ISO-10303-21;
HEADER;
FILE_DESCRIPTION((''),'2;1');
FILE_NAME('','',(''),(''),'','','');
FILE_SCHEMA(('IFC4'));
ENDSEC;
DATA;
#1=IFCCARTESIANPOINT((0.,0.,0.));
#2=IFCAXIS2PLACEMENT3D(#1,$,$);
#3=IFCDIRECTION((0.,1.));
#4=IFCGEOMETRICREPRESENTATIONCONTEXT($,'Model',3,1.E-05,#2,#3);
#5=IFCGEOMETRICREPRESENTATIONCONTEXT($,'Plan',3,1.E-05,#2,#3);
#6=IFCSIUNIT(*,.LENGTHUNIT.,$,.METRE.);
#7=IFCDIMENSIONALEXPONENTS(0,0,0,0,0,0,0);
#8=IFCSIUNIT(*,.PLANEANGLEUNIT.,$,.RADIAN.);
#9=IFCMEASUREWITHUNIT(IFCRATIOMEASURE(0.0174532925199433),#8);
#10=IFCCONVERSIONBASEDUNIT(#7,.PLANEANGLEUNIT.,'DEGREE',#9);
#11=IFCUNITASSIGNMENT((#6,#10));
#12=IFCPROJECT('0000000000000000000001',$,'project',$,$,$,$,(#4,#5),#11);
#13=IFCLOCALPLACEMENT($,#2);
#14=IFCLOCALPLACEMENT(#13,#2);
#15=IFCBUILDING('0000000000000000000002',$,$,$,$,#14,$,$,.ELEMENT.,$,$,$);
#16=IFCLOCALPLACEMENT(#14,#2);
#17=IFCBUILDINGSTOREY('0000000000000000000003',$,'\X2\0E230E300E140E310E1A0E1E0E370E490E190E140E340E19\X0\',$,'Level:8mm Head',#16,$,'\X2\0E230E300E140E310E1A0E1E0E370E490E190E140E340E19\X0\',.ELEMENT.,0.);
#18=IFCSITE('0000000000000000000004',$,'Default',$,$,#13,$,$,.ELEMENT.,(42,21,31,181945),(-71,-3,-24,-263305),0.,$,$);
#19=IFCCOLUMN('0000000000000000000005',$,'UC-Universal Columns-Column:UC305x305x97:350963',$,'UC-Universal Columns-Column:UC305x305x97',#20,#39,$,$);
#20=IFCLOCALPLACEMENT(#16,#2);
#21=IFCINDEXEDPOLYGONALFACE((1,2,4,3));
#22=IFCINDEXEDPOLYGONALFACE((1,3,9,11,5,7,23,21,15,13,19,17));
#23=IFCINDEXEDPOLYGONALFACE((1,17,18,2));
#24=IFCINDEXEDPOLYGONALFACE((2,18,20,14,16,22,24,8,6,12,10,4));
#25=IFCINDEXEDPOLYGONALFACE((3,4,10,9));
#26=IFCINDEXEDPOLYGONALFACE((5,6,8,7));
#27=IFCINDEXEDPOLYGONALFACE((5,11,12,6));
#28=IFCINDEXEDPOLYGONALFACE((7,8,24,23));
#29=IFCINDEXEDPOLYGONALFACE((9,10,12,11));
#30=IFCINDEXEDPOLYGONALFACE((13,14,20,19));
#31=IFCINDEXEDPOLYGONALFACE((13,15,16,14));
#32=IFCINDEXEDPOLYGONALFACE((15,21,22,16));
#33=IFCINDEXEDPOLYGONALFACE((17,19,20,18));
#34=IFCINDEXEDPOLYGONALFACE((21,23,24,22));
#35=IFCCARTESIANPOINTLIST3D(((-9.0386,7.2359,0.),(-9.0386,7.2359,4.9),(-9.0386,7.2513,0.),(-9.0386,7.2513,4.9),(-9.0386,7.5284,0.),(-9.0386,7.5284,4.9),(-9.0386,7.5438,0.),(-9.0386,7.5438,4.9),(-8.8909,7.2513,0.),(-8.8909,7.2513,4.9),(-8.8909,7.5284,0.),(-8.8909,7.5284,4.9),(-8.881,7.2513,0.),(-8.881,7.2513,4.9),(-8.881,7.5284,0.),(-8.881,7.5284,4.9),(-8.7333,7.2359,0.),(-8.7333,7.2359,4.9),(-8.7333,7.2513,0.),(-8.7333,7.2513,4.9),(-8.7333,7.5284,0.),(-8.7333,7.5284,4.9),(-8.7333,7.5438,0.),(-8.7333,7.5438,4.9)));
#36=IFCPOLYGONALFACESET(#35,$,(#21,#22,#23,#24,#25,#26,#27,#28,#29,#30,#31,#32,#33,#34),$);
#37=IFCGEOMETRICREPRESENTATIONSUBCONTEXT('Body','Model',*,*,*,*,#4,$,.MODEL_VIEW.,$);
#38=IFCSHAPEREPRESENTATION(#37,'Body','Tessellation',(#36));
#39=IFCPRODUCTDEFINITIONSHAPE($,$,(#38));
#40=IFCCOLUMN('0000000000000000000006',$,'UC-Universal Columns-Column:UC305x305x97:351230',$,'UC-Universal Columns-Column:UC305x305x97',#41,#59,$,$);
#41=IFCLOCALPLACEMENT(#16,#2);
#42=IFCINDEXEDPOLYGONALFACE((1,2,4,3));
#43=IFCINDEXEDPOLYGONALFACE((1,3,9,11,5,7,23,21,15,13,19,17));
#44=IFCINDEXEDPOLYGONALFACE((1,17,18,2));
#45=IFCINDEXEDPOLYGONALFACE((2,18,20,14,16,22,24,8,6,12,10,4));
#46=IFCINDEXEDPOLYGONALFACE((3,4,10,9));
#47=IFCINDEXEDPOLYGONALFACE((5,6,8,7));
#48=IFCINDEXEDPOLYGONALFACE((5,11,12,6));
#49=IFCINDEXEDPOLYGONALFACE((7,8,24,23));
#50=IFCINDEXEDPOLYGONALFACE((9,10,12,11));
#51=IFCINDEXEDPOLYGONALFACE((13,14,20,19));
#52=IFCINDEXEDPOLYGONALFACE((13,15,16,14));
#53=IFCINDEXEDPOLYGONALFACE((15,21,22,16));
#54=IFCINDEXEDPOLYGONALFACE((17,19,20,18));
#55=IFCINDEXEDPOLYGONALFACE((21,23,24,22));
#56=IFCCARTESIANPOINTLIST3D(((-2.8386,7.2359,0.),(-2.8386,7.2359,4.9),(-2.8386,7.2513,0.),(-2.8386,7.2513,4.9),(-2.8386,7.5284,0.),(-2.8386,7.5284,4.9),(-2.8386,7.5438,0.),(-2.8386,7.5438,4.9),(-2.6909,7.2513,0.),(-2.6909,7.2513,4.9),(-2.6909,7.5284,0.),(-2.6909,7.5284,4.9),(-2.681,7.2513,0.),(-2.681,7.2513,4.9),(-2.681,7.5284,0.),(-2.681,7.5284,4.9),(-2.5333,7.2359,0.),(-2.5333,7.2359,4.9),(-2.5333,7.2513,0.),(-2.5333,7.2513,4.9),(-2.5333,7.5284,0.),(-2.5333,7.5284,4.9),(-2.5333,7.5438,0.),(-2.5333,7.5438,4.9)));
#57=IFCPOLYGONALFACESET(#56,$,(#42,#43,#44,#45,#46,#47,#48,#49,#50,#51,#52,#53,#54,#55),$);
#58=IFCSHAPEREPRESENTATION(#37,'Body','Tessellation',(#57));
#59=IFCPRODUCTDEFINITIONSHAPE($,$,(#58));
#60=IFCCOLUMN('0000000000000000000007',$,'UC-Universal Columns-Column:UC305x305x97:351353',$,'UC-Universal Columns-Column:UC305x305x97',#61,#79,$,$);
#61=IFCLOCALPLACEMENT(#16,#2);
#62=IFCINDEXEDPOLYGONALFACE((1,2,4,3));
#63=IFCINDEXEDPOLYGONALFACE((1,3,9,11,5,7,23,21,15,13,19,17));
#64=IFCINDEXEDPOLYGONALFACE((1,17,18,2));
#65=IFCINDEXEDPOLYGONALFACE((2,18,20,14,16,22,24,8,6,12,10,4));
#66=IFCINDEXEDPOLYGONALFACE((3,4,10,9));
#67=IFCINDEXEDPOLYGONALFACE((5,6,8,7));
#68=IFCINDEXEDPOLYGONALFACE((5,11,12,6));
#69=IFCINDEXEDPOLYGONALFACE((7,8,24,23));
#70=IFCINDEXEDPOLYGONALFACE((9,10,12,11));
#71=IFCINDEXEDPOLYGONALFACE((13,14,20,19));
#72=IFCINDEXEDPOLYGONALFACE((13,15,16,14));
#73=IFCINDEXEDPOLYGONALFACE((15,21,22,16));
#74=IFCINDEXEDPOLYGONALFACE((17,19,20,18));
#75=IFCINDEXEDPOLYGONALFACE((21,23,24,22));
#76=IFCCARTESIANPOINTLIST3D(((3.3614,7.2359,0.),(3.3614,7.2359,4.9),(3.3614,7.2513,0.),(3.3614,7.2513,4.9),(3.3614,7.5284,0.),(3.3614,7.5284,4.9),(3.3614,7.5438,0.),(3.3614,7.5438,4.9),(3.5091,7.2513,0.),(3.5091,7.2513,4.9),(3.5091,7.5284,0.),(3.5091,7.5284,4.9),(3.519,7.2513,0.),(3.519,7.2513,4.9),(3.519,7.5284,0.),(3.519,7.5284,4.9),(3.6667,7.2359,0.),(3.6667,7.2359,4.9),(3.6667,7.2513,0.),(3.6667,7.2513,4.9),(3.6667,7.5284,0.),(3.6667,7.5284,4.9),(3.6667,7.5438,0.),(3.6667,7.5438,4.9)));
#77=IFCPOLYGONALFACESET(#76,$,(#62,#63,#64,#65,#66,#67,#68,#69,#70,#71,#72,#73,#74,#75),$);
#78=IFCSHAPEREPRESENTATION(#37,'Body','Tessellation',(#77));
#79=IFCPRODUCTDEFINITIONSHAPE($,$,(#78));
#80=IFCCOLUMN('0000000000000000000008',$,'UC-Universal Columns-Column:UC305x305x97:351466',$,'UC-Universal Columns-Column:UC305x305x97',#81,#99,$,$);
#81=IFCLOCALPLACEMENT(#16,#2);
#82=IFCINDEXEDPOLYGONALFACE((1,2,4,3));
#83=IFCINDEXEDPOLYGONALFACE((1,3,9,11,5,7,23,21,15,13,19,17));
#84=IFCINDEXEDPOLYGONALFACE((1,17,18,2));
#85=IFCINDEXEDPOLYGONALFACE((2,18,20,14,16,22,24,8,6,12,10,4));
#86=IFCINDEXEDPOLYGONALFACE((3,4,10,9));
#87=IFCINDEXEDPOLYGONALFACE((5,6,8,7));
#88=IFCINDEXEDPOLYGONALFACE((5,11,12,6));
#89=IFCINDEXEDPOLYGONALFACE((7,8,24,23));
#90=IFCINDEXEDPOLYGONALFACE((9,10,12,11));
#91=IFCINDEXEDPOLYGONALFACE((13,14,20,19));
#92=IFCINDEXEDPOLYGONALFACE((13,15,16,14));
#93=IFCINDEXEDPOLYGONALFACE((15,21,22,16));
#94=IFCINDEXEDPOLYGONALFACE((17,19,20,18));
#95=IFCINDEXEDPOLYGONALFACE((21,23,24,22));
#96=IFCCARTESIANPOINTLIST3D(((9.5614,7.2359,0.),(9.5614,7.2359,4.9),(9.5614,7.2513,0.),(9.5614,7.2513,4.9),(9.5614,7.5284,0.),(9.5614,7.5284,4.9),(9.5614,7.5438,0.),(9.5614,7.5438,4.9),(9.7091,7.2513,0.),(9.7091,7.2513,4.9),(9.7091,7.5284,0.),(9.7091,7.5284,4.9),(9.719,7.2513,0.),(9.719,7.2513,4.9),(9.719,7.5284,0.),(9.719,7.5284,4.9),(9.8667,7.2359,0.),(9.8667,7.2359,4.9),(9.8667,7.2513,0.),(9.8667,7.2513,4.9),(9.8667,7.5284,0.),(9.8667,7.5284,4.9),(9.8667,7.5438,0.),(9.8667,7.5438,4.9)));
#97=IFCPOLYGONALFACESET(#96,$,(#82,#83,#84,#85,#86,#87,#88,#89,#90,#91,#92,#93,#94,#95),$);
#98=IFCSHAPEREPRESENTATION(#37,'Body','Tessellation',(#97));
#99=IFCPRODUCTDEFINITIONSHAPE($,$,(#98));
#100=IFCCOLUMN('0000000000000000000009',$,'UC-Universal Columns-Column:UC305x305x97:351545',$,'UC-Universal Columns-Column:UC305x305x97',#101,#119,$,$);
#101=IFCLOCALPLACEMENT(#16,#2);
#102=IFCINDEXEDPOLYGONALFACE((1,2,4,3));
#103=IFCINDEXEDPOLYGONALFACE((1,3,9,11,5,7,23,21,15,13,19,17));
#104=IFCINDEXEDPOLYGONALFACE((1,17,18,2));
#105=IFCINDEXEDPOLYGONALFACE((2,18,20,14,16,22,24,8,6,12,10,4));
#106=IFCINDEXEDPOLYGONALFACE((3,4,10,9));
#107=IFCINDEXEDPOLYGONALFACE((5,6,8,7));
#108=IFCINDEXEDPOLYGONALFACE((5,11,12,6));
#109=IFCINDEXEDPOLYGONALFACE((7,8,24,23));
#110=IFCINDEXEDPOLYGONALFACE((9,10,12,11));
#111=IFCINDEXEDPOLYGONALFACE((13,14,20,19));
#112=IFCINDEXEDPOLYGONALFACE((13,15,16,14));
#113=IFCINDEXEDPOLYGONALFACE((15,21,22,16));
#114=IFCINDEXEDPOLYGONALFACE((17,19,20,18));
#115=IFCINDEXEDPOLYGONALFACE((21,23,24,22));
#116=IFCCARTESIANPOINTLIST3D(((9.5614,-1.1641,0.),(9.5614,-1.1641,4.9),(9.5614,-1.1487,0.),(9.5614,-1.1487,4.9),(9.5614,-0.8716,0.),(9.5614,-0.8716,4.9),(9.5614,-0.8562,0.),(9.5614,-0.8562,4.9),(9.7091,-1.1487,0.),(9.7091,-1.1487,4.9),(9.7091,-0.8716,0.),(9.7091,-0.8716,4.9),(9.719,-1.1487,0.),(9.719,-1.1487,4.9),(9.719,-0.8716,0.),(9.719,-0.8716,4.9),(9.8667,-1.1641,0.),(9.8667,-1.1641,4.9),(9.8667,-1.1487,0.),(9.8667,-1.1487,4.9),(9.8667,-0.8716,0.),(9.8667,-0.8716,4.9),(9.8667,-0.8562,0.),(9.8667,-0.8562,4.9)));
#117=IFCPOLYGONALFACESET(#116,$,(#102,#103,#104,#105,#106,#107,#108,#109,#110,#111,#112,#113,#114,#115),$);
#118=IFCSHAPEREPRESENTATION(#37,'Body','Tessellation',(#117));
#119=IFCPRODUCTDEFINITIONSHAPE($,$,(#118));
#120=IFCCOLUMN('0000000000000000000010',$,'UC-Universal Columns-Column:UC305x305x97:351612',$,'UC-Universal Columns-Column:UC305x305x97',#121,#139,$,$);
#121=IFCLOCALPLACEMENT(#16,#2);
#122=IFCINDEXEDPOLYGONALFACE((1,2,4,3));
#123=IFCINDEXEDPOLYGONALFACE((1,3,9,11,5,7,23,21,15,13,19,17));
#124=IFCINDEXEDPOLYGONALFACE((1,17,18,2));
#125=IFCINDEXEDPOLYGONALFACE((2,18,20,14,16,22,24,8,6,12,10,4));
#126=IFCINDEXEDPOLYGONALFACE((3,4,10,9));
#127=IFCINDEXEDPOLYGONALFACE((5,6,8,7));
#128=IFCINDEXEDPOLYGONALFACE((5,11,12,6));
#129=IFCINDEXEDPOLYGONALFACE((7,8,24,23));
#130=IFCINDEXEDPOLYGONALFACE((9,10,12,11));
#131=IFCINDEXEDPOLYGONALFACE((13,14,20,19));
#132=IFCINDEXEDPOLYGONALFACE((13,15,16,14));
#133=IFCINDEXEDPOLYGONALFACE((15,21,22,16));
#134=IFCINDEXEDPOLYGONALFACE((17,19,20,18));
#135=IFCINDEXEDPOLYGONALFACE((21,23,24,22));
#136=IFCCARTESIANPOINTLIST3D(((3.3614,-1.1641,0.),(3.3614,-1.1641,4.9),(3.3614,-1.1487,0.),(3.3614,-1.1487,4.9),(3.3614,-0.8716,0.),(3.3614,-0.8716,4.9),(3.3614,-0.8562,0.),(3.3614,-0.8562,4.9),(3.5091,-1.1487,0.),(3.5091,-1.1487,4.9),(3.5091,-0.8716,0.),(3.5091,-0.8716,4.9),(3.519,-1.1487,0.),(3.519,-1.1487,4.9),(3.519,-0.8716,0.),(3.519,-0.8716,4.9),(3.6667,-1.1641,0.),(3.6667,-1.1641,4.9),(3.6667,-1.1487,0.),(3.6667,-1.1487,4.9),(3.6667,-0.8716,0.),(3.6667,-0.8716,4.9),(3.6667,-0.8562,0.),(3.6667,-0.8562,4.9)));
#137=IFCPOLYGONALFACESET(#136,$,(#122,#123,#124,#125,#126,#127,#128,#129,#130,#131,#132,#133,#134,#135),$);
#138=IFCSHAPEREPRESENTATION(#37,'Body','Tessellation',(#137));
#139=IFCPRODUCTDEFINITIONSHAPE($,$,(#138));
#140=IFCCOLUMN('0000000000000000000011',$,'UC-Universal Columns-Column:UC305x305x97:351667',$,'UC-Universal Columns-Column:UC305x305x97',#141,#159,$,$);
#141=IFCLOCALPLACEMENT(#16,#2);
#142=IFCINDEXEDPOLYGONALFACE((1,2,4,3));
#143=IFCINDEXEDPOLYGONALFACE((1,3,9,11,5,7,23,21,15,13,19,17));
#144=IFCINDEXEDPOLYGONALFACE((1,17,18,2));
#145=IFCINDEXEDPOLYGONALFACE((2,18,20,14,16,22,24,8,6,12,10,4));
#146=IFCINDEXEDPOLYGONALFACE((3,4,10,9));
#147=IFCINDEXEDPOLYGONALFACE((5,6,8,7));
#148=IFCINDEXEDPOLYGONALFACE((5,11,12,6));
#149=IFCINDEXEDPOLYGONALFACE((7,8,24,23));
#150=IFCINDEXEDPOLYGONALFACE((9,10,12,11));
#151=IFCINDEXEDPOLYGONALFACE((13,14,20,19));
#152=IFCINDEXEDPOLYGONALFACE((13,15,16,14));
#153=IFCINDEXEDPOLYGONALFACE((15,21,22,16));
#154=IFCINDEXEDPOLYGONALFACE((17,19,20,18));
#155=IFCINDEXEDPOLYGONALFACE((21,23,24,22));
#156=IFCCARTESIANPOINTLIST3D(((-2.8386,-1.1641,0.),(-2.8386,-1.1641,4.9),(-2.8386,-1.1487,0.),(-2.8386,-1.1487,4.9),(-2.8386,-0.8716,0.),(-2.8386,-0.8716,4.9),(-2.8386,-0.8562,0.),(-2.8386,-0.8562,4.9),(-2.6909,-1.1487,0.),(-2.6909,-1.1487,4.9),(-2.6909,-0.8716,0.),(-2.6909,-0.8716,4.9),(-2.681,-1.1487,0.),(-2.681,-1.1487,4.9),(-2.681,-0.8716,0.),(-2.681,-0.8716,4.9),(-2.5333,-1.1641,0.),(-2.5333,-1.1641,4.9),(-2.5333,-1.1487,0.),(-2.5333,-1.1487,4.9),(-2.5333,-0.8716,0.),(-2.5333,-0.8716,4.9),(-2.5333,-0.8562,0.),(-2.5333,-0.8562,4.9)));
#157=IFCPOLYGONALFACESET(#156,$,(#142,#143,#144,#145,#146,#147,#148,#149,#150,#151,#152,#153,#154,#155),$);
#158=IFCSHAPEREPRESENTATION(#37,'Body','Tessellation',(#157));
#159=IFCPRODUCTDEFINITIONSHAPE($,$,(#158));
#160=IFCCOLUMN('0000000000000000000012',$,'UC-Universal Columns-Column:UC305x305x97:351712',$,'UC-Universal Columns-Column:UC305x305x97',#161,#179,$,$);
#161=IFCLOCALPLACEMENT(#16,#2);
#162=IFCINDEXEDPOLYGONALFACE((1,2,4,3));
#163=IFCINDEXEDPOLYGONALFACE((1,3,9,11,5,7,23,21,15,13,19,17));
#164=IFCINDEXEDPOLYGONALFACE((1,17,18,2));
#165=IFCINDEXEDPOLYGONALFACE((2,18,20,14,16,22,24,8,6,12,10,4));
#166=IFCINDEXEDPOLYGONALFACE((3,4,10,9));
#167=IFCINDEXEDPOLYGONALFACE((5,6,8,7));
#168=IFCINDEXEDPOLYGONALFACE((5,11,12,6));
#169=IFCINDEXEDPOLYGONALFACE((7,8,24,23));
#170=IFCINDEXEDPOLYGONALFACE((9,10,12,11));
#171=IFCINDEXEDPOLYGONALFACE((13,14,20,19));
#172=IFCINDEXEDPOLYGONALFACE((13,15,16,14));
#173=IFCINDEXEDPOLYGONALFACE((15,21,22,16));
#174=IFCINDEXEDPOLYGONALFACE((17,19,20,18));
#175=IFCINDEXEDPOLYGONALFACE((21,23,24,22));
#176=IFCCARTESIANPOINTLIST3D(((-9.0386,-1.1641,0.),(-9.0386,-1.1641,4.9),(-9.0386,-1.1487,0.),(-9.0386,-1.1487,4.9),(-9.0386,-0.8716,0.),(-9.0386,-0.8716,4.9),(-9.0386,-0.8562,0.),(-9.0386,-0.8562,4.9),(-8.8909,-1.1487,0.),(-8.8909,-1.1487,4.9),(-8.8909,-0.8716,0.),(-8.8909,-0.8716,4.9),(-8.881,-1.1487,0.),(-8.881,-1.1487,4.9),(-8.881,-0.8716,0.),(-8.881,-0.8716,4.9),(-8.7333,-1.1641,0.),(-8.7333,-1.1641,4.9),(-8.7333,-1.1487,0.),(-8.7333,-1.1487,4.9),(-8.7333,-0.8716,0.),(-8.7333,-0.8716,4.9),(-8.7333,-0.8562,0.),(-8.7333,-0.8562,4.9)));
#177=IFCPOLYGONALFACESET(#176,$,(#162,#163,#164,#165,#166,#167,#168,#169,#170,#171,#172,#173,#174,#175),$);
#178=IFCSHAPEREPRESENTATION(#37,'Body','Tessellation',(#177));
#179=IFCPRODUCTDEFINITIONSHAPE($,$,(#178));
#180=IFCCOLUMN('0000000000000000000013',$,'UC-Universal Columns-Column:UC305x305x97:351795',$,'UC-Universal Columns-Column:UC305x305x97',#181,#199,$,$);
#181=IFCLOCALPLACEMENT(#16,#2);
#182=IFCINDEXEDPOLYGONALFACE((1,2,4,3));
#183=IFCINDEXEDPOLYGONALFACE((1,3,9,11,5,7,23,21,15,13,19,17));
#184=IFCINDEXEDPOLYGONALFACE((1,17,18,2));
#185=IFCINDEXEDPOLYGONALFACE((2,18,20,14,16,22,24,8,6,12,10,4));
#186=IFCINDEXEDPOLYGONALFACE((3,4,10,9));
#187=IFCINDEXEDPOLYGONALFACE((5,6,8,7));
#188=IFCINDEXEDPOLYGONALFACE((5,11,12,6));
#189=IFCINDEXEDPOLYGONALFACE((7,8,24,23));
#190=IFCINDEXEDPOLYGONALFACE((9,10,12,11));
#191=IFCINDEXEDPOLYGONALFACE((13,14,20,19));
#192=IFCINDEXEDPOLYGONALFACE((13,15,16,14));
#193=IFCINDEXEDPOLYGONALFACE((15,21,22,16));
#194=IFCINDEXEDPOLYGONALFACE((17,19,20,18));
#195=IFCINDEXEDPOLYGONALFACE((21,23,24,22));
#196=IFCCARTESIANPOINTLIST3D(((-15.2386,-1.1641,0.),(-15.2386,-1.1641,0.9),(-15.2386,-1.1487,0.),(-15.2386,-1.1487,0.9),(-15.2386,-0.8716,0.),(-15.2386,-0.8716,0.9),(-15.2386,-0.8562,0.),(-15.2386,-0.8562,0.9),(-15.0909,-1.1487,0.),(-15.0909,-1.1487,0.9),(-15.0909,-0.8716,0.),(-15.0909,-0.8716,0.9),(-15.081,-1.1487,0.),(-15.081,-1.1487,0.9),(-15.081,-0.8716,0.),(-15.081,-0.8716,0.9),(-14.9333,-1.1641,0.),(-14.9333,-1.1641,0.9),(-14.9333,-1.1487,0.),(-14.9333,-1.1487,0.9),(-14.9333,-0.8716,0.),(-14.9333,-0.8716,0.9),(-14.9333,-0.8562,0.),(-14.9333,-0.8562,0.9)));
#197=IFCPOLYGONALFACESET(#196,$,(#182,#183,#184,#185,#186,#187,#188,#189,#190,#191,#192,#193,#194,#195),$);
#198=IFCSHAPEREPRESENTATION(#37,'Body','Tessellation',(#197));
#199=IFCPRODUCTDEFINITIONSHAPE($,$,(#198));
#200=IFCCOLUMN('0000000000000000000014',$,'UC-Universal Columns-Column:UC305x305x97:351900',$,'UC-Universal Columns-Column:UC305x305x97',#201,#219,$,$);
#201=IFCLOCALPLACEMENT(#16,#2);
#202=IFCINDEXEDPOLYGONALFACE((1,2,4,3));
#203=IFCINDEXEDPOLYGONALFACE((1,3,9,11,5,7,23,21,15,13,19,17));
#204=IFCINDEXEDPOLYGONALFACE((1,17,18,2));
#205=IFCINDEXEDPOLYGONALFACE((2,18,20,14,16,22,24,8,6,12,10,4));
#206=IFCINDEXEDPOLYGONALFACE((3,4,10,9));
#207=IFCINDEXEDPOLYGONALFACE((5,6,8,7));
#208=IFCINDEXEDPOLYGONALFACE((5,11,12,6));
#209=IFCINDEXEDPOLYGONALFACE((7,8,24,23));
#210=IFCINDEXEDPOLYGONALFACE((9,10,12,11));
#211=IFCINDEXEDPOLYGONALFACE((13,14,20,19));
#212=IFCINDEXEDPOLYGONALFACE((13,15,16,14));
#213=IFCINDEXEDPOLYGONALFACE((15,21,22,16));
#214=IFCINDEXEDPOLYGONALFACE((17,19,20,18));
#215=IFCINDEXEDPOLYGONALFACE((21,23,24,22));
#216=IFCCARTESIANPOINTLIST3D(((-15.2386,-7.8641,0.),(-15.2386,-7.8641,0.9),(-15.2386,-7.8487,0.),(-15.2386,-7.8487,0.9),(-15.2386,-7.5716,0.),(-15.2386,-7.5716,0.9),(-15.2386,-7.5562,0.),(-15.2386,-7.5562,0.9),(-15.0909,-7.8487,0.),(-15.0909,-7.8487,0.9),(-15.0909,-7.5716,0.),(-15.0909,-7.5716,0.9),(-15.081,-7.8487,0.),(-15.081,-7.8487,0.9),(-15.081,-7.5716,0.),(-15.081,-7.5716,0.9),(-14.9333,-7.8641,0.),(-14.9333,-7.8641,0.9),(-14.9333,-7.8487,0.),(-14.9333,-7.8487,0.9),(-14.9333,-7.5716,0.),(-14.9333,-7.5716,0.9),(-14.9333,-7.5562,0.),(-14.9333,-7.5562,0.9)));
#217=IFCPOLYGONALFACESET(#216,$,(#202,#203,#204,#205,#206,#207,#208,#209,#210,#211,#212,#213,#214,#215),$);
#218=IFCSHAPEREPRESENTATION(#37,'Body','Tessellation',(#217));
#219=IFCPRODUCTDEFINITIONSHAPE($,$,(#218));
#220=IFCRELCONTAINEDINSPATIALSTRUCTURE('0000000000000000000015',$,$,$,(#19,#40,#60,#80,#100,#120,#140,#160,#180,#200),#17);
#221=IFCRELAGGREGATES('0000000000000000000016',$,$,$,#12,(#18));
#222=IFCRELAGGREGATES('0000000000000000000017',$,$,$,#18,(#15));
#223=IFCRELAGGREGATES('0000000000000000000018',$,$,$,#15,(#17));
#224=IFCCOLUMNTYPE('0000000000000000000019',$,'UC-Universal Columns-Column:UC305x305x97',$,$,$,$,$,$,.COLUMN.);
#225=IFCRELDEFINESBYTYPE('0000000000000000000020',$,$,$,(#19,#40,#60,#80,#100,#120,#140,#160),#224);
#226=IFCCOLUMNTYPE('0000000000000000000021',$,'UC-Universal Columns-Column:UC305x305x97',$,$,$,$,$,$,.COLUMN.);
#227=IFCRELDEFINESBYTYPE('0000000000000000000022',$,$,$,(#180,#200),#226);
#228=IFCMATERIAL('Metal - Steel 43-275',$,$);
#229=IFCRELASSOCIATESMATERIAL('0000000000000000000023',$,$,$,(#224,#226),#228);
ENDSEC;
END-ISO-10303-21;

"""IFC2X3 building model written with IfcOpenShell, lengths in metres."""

from ifc_helpers import new_model, entity, si_unit, converted_unit, direction, frame, frame_2d, origin, place, context, subcontext, project, spatial, i_section, extrude, source, transform, mapped, material, type_object, type_shapes, element, save


model = new_model("IFC2X3")

# Units and contexts
model_context = context("Model", 3, precision=1e-05, world=origin(), true_north=direction((0.0, 1.0)))
plan_context = context("Plan", 3, precision=1e-05, world=origin(), true_north=direction((0.0, 1.0)))
body_context = subcontext(model_context, "Body", "Model", "MODEL_VIEW")
ifc_project = project(units=[si_unit("LENGTHUNIT", "METRE"), converted_unit("PLANEANGLEUNIT", "DEGREE", entity("IfcRatioMeasure", 0.0174532925199433), si_unit("PLANEANGLEUNIT", "RADIAN"), dimensions=[0, 0, 0, 0, 0, 0, 0])], contexts=[model_context, plan_context])

# Site, building, storey
site_placement = place(None, origin())
site = spatial("IfcSite", under=ifc_project, at=site_placement, Name="Default", CompositionType="ELEMENT", RefLatitude=(42, 21, 31, 181945), RefLongitude=(-71, -3, -24, -263305), RefElevation=0.0)
building_placement = place(site_placement, origin())
building = spatial("IfcBuilding", under=site, at=building_placement, CompositionType="ELEMENT")
storey_placement = place(building_placement, origin())
storey = spatial("IfcBuildingStorey", under=building, at=storey_placement, Name="ระดับพื้นดิน", ObjectType="Level:8mm Head", LongName="ระดับพื้นดิน", CompositionType="ELEMENT", Elevation=0.0)

# Columns
ifc_material_1 = material(Name="Metal - Steel 43-275")
column_type_1 = type_object("IfcColumnType", Name="UC-Universal Columns-Column:UC305x305x97", PredefinedType="COLUMN", material=ifc_material_1)
shared_shape_1 = source(origin(), body_context, "Body", "SweptSolid", [
    extrude(i_section(OverallWidth=0.3053, OverallDepth=0.3079, WebThickness=0.0099, FlangeThickness=0.0154, at=frame_2d((0.0, 0.0), x_axis=(0.0, 1.0))), frame((0.0, 0.0, 0.0), z_axis=(0.0, 0.0, 1.0), x_axis=(0.0, -1.0, 0.0)), (0.0, 0.0, 1.0), 4.9),
])
type_shapes(column_type_1, [shared_shape_1])
for number, where, name in (
    (1, (-8.8859, 7.3898, 0.0), "UC-Universal Columns-Column:UC305x305x97:350963"),
    (2, (-2.6859, 7.3898, 0.0), "UC-Universal Columns-Column:UC305x305x97:351230"),
    (3, (3.5141, 7.3898, 0.0), "UC-Universal Columns-Column:UC305x305x97:351353"),
    (4, (9.7141, 7.3898, 0.0), "UC-Universal Columns-Column:UC305x305x97:351466"),
    (5, (9.7141, -1.0102, 0.0), "UC-Universal Columns-Column:UC305x305x97:351545"),
    (6, (3.5141, -1.0102, 0.0), "UC-Universal Columns-Column:UC305x305x97:351612"),
    (7, (-2.6859, -1.0102, 0.0), "UC-Universal Columns-Column:UC305x305x97:351667"),
    (8, (-8.8859, -1.0102, 0.0), "UC-Universal Columns-Column:UC305x305x97:351712"),
):
    element("IfcColumn", number, at=place(storey_placement, frame(where)), inside=storey, type_object=column_type_1, Name=name, ObjectType="UC-Universal Columns-Column:UC305x305x97", context=body_context, shape_type="MappedRepresentation", body=[
        mapped(shared_shape_1, transform((0.0, 0.0, 0.0), scale=1.0)),
    ])
column_type_2 = type_object("IfcColumnType", Name="UC-Universal Columns-Column:UC305x305x97", PredefinedType="COLUMN", material=ifc_material_1)
shared_shape_2 = source(origin(), body_context, "Body", "SweptSolid", [
    extrude(i_section(OverallWidth=0.3053, OverallDepth=0.3079, WebThickness=0.0099, FlangeThickness=0.0154, at=frame_2d((0.0, 0.0), x_axis=(0.0, 1.0))), frame((0.0, 0.0, 0.0), z_axis=(0.0, 0.0, 1.0), x_axis=(0.0, -1.0, 0.0)), (0.0, 0.0, 1.0), 0.9),
])
type_shapes(column_type_2, [shared_shape_2])
for number, where, name in (
    (9, (-15.0859, -1.0102, 0.0), "UC-Universal Columns-Column:UC305x305x97:351795"),
    (10, (-15.0859, -7.7102, 0.0), "UC-Universal Columns-Column:UC305x305x97:351900"),
):
    element("IfcColumn", number, at=place(storey_placement, frame(where)), inside=storey, type_object=column_type_2, Name=name, ObjectType="UC-Universal Columns-Column:UC305x305x97", context=body_context, shape_type="MappedRepresentation", body=[
        mapped(shared_shape_2, transform((0.0, 0.0, 0.0), scale=1.0)),
    ])

save(model, "model.ifc")
